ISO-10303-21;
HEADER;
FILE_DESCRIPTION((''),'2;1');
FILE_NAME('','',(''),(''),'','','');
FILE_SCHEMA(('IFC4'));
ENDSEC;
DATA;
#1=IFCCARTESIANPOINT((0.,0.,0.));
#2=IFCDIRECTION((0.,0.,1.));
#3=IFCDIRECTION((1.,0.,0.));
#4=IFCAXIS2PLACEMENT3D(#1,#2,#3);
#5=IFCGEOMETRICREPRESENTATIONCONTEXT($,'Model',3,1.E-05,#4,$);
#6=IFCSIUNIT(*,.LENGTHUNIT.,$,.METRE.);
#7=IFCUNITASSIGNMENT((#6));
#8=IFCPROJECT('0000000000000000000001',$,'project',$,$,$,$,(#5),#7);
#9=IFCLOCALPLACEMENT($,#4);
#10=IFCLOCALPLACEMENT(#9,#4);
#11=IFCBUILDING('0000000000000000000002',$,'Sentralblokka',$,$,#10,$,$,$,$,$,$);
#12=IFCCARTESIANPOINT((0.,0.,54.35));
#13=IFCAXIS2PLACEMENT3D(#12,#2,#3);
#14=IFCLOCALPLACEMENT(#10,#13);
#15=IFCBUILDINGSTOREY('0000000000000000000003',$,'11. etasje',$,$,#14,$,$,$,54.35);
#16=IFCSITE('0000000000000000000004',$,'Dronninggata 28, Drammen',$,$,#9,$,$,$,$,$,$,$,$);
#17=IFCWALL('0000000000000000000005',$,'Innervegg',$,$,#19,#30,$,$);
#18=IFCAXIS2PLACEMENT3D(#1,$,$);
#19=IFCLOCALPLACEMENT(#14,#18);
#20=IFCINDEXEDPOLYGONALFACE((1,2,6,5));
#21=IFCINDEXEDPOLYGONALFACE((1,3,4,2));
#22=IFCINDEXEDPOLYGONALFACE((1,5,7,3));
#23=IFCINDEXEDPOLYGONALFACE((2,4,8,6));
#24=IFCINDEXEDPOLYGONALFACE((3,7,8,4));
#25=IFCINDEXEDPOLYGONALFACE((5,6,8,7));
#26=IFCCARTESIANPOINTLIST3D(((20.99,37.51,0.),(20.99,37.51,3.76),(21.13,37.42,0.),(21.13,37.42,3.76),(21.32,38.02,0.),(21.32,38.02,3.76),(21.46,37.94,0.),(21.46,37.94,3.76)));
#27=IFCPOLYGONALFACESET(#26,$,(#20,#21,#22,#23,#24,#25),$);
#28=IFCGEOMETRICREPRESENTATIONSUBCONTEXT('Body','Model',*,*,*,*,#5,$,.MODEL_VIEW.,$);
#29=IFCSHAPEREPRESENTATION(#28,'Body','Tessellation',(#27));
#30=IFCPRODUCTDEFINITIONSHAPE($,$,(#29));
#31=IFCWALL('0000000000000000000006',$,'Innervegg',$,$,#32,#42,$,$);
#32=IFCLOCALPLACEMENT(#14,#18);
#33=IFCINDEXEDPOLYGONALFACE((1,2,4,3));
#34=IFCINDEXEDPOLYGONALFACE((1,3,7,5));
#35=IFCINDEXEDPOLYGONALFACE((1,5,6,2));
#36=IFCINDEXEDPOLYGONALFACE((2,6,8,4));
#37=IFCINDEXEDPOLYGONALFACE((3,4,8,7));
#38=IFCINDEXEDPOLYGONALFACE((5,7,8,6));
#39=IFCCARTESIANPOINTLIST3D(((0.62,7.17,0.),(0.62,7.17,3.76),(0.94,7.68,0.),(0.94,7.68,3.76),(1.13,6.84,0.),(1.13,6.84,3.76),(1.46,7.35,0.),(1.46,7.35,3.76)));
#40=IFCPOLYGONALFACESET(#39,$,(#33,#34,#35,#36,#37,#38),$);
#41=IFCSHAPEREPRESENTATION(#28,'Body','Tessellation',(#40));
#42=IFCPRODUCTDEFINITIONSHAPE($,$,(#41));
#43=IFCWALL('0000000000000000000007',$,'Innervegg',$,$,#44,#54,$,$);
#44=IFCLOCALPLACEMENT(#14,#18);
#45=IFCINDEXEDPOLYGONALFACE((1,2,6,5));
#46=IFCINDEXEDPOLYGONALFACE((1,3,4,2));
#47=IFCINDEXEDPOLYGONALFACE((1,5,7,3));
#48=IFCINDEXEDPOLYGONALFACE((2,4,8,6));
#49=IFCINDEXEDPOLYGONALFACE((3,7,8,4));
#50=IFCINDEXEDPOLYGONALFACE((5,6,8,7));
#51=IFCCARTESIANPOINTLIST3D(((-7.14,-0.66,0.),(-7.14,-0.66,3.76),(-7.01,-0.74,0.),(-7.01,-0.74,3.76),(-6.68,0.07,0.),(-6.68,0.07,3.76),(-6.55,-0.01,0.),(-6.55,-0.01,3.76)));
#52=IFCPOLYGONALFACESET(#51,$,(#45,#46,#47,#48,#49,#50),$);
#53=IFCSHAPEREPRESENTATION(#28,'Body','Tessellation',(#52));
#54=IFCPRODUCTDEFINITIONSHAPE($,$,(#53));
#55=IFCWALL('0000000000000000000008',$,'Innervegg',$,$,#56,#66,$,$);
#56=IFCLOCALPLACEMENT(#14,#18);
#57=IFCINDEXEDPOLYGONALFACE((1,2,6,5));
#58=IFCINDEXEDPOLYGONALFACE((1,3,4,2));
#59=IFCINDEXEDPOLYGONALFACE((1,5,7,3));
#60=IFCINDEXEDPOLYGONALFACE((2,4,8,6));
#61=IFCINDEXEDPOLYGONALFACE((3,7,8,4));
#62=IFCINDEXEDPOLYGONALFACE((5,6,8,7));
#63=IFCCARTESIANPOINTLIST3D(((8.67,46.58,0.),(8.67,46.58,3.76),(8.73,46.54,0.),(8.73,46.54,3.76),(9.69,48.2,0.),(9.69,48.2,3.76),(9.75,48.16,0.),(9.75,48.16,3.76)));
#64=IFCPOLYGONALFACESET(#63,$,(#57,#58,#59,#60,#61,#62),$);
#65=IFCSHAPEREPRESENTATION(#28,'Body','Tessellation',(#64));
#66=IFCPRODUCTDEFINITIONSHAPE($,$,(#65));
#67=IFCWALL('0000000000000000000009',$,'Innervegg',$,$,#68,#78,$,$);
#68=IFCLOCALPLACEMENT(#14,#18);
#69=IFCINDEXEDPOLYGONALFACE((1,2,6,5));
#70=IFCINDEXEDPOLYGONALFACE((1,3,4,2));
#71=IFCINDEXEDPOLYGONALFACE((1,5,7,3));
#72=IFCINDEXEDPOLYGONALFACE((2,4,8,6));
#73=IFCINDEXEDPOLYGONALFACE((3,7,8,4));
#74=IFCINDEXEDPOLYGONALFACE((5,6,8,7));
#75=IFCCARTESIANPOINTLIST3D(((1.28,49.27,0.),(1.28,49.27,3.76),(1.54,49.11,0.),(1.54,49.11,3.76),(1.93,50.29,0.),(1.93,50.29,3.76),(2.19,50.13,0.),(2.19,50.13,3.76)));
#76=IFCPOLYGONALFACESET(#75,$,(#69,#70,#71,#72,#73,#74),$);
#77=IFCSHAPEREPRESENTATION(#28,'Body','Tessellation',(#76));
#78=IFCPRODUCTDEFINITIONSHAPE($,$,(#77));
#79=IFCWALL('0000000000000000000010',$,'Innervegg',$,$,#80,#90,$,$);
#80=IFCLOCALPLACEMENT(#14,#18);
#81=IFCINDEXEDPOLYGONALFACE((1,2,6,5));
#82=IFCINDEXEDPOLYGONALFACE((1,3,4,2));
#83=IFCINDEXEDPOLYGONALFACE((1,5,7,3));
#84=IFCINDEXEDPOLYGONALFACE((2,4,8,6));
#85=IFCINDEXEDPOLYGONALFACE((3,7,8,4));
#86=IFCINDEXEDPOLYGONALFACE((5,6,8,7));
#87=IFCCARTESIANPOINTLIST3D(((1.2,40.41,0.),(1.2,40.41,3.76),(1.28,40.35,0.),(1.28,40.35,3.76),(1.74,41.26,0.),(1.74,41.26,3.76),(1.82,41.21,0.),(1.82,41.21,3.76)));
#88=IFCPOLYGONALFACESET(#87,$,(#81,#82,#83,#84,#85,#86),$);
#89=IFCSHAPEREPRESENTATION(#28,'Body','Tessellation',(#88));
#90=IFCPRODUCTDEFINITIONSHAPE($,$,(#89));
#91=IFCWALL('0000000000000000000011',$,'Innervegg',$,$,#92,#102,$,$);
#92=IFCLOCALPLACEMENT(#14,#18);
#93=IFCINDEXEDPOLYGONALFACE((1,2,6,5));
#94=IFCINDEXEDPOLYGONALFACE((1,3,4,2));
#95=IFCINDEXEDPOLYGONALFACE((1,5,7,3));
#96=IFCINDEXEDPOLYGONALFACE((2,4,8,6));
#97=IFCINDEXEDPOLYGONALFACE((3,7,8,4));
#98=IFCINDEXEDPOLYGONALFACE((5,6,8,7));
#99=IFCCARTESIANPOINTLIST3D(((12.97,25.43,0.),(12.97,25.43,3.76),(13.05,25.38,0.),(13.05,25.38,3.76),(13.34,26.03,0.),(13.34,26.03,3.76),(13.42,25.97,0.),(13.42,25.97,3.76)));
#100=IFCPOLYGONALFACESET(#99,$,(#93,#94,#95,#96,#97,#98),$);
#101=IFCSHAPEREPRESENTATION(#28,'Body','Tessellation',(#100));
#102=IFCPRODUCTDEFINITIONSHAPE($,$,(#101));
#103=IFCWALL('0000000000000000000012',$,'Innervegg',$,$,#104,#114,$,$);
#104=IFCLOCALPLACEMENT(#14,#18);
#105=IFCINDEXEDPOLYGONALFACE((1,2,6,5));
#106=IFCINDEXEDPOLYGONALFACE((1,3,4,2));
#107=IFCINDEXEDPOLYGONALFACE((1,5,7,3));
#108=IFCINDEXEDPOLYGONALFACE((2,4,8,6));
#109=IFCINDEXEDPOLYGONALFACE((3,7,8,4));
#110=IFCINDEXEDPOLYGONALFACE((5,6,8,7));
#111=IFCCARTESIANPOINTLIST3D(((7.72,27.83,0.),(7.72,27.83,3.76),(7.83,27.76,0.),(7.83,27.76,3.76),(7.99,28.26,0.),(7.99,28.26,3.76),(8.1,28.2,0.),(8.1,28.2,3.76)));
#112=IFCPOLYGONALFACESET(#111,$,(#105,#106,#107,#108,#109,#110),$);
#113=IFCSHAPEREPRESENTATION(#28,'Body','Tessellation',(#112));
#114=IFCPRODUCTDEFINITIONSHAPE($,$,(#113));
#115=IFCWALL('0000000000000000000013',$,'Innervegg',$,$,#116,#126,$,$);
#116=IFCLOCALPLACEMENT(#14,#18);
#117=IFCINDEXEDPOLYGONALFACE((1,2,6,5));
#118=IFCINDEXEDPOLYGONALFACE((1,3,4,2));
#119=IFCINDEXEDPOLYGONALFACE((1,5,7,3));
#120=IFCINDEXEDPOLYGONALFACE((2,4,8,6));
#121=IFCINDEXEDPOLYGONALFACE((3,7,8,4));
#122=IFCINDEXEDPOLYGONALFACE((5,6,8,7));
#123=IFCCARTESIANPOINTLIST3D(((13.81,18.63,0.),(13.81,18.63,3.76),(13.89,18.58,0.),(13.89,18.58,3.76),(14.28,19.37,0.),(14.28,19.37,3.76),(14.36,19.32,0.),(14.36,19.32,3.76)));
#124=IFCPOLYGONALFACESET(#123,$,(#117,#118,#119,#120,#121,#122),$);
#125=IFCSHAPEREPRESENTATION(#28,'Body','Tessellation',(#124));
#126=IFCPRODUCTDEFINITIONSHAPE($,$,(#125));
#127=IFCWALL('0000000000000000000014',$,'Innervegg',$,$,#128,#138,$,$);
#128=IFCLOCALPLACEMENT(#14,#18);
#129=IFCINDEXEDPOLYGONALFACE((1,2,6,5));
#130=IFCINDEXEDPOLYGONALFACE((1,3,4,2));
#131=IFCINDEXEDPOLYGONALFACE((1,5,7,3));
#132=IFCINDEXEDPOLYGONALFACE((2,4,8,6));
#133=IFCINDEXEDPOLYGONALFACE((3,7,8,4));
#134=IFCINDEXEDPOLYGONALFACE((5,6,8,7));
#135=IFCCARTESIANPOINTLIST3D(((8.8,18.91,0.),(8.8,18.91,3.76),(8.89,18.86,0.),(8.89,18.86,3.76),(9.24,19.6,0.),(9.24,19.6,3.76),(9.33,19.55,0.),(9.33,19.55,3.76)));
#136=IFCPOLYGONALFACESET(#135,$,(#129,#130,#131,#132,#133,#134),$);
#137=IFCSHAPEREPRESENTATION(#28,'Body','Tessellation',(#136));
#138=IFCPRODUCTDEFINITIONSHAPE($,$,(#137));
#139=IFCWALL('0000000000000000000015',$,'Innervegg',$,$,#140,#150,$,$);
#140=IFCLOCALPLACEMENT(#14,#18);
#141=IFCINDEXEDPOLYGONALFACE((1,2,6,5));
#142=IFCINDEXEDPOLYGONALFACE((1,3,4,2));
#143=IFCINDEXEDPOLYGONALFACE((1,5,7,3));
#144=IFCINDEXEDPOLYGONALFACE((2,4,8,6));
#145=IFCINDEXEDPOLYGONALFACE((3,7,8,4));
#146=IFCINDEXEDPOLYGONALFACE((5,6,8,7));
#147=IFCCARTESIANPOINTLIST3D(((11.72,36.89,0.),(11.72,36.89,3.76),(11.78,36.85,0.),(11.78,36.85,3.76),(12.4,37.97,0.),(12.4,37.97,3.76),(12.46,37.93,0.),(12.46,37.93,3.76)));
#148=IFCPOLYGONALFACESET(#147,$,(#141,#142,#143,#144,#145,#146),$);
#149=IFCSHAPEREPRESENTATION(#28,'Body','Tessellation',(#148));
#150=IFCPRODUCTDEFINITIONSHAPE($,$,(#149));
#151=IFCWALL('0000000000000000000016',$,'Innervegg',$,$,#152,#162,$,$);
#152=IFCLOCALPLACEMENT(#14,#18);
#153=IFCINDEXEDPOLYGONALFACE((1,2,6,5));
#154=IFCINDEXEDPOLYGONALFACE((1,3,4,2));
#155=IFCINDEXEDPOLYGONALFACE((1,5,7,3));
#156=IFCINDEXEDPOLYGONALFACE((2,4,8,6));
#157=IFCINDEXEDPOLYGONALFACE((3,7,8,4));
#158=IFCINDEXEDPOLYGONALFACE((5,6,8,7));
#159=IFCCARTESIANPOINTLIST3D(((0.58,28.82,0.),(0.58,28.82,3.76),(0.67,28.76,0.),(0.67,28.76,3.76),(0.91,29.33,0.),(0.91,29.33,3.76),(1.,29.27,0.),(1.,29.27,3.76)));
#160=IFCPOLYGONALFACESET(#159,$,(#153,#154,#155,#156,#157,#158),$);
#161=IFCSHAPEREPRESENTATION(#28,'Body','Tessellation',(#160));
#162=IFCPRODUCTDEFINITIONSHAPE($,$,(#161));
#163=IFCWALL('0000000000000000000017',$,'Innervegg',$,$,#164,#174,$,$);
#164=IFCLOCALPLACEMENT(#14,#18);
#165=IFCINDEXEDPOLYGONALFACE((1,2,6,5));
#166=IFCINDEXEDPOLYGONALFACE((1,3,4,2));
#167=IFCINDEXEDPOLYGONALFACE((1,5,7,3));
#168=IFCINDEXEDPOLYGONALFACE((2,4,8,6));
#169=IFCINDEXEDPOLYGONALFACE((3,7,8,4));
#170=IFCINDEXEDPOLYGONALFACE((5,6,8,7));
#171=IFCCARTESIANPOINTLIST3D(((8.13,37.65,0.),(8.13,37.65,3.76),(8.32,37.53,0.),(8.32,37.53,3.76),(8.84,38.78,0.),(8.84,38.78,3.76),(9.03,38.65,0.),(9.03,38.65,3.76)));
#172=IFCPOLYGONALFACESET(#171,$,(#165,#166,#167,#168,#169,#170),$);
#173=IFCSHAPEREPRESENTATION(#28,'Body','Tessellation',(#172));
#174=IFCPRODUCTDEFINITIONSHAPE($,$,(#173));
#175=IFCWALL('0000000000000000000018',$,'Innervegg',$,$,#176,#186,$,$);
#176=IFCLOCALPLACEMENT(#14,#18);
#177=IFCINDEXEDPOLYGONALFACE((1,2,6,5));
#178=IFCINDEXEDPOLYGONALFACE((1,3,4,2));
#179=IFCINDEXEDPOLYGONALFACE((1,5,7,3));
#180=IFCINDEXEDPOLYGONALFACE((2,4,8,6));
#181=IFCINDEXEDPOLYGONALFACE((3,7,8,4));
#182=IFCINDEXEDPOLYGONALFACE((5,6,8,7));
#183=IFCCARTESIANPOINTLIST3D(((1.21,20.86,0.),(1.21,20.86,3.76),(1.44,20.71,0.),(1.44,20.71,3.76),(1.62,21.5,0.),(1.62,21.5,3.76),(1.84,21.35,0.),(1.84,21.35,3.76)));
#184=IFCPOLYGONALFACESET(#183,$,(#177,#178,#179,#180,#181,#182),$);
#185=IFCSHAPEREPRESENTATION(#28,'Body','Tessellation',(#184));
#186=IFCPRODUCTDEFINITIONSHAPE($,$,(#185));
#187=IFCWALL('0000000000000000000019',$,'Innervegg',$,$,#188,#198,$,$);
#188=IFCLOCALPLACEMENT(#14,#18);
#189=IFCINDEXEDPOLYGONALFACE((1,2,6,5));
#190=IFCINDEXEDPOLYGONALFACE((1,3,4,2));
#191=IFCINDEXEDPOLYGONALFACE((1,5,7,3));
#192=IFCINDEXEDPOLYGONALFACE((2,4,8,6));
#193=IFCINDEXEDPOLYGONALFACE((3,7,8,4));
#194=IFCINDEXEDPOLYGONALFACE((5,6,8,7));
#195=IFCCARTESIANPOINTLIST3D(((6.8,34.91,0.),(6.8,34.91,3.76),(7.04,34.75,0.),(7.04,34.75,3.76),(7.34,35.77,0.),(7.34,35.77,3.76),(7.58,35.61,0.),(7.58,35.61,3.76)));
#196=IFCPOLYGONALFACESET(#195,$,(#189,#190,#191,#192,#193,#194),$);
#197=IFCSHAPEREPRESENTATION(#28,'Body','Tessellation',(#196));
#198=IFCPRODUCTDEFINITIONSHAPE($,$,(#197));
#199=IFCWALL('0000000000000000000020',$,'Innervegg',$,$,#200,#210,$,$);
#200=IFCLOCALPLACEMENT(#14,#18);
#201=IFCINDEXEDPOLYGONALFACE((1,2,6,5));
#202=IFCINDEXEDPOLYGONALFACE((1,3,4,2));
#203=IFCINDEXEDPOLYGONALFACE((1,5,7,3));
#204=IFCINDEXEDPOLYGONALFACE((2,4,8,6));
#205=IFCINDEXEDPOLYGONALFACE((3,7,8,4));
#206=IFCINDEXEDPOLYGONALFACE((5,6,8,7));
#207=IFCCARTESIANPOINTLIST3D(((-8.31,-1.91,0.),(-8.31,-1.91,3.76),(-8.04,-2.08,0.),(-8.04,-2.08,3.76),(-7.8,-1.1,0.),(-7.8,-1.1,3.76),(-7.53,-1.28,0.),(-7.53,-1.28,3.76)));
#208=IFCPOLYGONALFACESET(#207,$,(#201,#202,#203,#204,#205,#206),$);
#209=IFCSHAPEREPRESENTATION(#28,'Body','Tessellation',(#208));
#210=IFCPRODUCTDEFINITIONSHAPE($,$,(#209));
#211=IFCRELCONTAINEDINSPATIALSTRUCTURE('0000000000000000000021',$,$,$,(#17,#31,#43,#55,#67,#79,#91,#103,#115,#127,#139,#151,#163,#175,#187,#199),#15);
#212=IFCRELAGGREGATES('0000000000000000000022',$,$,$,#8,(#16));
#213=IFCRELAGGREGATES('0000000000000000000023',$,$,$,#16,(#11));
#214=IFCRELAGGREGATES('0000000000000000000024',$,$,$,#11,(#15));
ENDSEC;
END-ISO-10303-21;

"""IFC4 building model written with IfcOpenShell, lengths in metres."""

from ifc_helpers import new_model, si_unit, frame, origin_with_axes, place, context, subcontext, project, spatial, polyline, outline, extrude, element, save


model = new_model("IFC4")

# Units and contexts
model_context = context("Model", 3, precision=1e-05, world=origin_with_axes())
body_context = subcontext(model_context, "Body", "Model", "MODEL_VIEW")
ifc_project = project(units=[si_unit("LENGTHUNIT", "METRE")], contexts=[model_context])

# Site, building, storey
site_placement = place(None, origin_with_axes())
site = spatial("IfcSite", under=ifc_project, at=site_placement, Name="Dronninggata 28, Drammen")
building_placement = place(site_placement, origin_with_axes())
building = spatial("IfcBuilding", under=site, at=building_placement, Name="Sentralblokka")
storey_placement = place(building_placement, frame((0.0, 0.0, 54.35), z_axis=(0.0, 0.0, 1.0), x_axis=(1.0, 0.0, 0.0)))
storey = spatial("IfcBuildingStorey", under=building, at=storey_placement, Name="11. etasje", Elevation=54.35)

# Walls
wall_1_placement = place(storey_placement, frame((0.0, 0.0, -54.35), z_axis=(0.0, 0.0, 1.0), x_axis=(1.0, 0.0, 0.0)))
element("IfcWall", 1, at=wall_1_placement, inside=storey, Name="Innervegg", context=body_context, shape_type="SweptSolid", body=[
    extrude(outline(polyline([(21.46, 37.94), (21.13, 37.42), (20.99, 37.51), (21.32, 38.02), (21.46, 37.94)])), frame((0.0, 0.0, 54.35)), (0.0, 0.0, 1.0), 3.76),
])
wall_2_placement = place(storey_placement, frame((0.0, 0.0, -54.35), z_axis=(0.0, 0.0, 1.0), x_axis=(1.0, 0.0, 0.0)))
element("IfcWall", 2, at=wall_2_placement, inside=storey, Name="Innervegg", context=body_context, shape_type="SweptSolid", body=[
    extrude(outline(polyline([(1.46, 7.35), (1.13, 6.84), (0.62, 7.17), (0.94, 7.68), (1.46, 7.35)])), frame((0.0, 0.0, 54.35)), (0.0, 0.0, 1.0), 3.76),
])
wall_3_placement = place(storey_placement, frame((0.0, 0.0, -54.35), z_axis=(0.0, 0.0, 1.0), x_axis=(1.0, 0.0, 0.0)))
element("IfcWall", 3, at=wall_3_placement, inside=storey, Name="Innervegg", context=body_context, shape_type="SweptSolid", body=[
    extrude(outline(polyline([(-6.55, -0.01), (-7.01, -0.74), (-7.14, -0.66), (-6.68, 0.07), (-6.55, -0.01)])), frame((0.0, 0.0, 54.35)), (0.0, 0.0, 1.0), 3.76),
])
wall_4_placement = place(storey_placement, frame((0.0, 0.0, -54.35), z_axis=(0.0, 0.0, 1.0), x_axis=(1.0, 0.0, 0.0)))
element("IfcWall", 4, at=wall_4_placement, inside=storey, Name="Innervegg", context=body_context, shape_type="SweptSolid", body=[
    extrude(outline(polyline([(9.75, 48.16), (8.73, 46.54), (8.67, 46.58), (9.69, 48.2), (9.75, 48.16)])), frame((0.0, 0.0, 54.35)), (0.0, 0.0, 1.0), 3.76),
])
wall_5_placement = place(storey_placement, frame((0.0, 0.0, -54.35), z_axis=(0.0, 0.0, 1.0), x_axis=(1.0, 0.0, 0.0)))
element("IfcWall", 5, at=wall_5_placement, inside=storey, Name="Innervegg", context=body_context, shape_type="SweptSolid", body=[
    extrude(outline(polyline([(2.19, 50.13), (1.54, 49.11), (1.28, 49.27), (1.93, 50.29), (2.19, 50.13)])), frame((0.0, 0.0, 54.35)), (0.0, 0.0, 1.0), 3.76),
])
wall_6_placement = place(storey_placement, frame((0.0, 0.0, -54.35), z_axis=(0.0, 0.0, 1.0), x_axis=(1.0, 0.0, 0.0)))
element("IfcWall", 6, at=wall_6_placement, inside=storey, Name="Innervegg", context=body_context, shape_type="SweptSolid", body=[
    extrude(outline(polyline([(1.82, 41.21), (1.28, 40.35), (1.2, 40.41), (1.74, 41.26), (1.82, 41.21)])), frame((0.0, 0.0, 54.35)), (0.0, 0.0, 1.0), 3.76),
])
wall_7_placement = place(storey_placement, frame((0.0, 0.0, -54.35), z_axis=(0.0, 0.0, 1.0), x_axis=(1.0, 0.0, 0.0)))
element("IfcWall", 7, at=wall_7_placement, inside=storey, Name="Innervegg", context=body_context, shape_type="SweptSolid", body=[
    extrude(outline(polyline([(13.42, 25.97), (13.05, 25.38), (12.97, 25.43), (13.34, 26.03), (13.42, 25.97)])), frame((0.0, 0.0, 54.35)), (0.0, 0.0, 1.0), 3.76),
])
wall_8_placement = place(storey_placement, frame((0.0, 0.0, -54.35), z_axis=(0.0, 0.0, 1.0), x_axis=(1.0, 0.0, 0.0)))
element("IfcWall", 8, at=wall_8_placement, inside=storey, Name="Innervegg", context=body_context, shape_type="SweptSolid", body=[
    extrude(outline(polyline([(8.1, 28.2), (7.83, 27.76), (7.72, 27.83), (7.99, 28.26), (8.1, 28.2)])), frame((0.0, 0.0, 54.35)), (0.0, 0.0, 1.0), 3.76),
])
wall_9_placement = place(storey_placement, frame((0.0, 0.0, -54.35), z_axis=(0.0, 0.0, 1.0), x_axis=(1.0, 0.0, 0.0)))
element("IfcWall", 9, at=wall_9_placement, inside=storey, Name="Innervegg", context=body_context, shape_type="SweptSolid", body=[
    extrude(outline(polyline([(14.36, 19.32), (13.89, 18.58), (13.81, 18.63), (14.28, 19.37), (14.36, 19.32)])), frame((0.0, 0.0, 54.35)), (0.0, 0.0, 1.0), 3.76),
])
wall_10_placement = place(storey_placement, frame((0.0, 0.0, -54.35), z_axis=(0.0, 0.0, 1.0), x_axis=(1.0, 0.0, 0.0)))
element("IfcWall", 10, at=wall_10_placement, inside=storey, Name="Innervegg", context=body_context, shape_type="SweptSolid", body=[
    extrude(outline(polyline([(9.33, 19.55), (8.89, 18.86), (8.8, 18.91), (9.24, 19.6), (9.33, 19.55)])), frame((0.0, 0.0, 54.35)), (0.0, 0.0, 1.0), 3.76),
])
wall_11_placement = place(storey_placement, frame((0.0, 0.0, -54.35), z_axis=(0.0, 0.0, 1.0), x_axis=(1.0, 0.0, 0.0)))
element("IfcWall", 11, at=wall_11_placement, inside=storey, Name="Innervegg", context=body_context, shape_type="SweptSolid", body=[
    extrude(outline(polyline([(12.46, 37.93), (11.78, 36.85), (11.72, 36.89), (12.4, 37.97), (12.46, 37.93)])), frame((0.0, 0.0, 54.35)), (0.0, 0.0, 1.0), 3.76),
])
wall_12_placement = place(storey_placement, frame((0.0, 0.0, -54.35), z_axis=(0.0, 0.0, 1.0), x_axis=(1.0, 0.0, 0.0)))
element("IfcWall", 12, at=wall_12_placement, inside=storey, Name="Innervegg", context=body_context, shape_type="SweptSolid", body=[
    extrude(outline(polyline([(1.0, 29.27), (0.67, 28.76), (0.58, 28.82), (0.91, 29.33), (1.0, 29.27)])), frame((0.0, 0.0, 54.35)), (0.0, 0.0, 1.0), 3.76),
])
wall_13_placement = place(storey_placement, frame((0.0, 0.0, -54.35), z_axis=(0.0, 0.0, 1.0), x_axis=(1.0, 0.0, 0.0)))
element("IfcWall", 13, at=wall_13_placement, inside=storey, Name="Innervegg", context=body_context, shape_type="SweptSolid", body=[
    extrude(outline(polyline([(9.03, 38.65), (8.32, 37.53), (8.13, 37.65), (8.84, 38.78), (9.03, 38.65)])), frame((0.0, 0.0, 54.35)), (0.0, 0.0, 1.0), 3.76),
])
wall_14_placement = place(storey_placement, frame((0.0, 0.0, -54.35), z_axis=(0.0, 0.0, 1.0), x_axis=(1.0, 0.0, 0.0)))
element("IfcWall", 14, at=wall_14_placement, inside=storey, Name="Innervegg", context=body_context, shape_type="SweptSolid", body=[
    extrude(outline(polyline([(1.84, 21.35), (1.44, 20.71), (1.21, 20.86), (1.62, 21.5), (1.84, 21.35)])), frame((0.0, 0.0, 54.35)), (0.0, 0.0, 1.0), 3.76),
])
wall_15_placement = place(storey_placement, frame((0.0, 0.0, -54.35), z_axis=(0.0, 0.0, 1.0), x_axis=(1.0, 0.0, 0.0)))
element("IfcWall", 15, at=wall_15_placement, inside=storey, Name="Innervegg", context=body_context, shape_type="SweptSolid", body=[
    extrude(outline(polyline([(7.58, 35.61), (7.04, 34.75), (6.8, 34.91), (7.34, 35.77), (7.58, 35.61)])), frame((0.0, 0.0, 54.35)), (0.0, 0.0, 1.0), 3.76),
])
wall_16_placement = place(storey_placement, frame((0.0, 0.0, -54.35), z_axis=(0.0, 0.0, 1.0), x_axis=(1.0, 0.0, 0.0)))
element("IfcWall", 16, at=wall_16_placement, inside=storey, Name="Innervegg", context=body_context, shape_type="SweptSolid", body=[
    extrude(outline(polyline([(-7.53, -1.28), (-8.04, -2.08), (-8.31, -1.91), (-7.8, -1.1), (-7.53, -1.28)])), frame((0.0, 0.0, 54.35)), (0.0, 0.0, 1.0), 3.76),
])

save(model, "model.ifc")
